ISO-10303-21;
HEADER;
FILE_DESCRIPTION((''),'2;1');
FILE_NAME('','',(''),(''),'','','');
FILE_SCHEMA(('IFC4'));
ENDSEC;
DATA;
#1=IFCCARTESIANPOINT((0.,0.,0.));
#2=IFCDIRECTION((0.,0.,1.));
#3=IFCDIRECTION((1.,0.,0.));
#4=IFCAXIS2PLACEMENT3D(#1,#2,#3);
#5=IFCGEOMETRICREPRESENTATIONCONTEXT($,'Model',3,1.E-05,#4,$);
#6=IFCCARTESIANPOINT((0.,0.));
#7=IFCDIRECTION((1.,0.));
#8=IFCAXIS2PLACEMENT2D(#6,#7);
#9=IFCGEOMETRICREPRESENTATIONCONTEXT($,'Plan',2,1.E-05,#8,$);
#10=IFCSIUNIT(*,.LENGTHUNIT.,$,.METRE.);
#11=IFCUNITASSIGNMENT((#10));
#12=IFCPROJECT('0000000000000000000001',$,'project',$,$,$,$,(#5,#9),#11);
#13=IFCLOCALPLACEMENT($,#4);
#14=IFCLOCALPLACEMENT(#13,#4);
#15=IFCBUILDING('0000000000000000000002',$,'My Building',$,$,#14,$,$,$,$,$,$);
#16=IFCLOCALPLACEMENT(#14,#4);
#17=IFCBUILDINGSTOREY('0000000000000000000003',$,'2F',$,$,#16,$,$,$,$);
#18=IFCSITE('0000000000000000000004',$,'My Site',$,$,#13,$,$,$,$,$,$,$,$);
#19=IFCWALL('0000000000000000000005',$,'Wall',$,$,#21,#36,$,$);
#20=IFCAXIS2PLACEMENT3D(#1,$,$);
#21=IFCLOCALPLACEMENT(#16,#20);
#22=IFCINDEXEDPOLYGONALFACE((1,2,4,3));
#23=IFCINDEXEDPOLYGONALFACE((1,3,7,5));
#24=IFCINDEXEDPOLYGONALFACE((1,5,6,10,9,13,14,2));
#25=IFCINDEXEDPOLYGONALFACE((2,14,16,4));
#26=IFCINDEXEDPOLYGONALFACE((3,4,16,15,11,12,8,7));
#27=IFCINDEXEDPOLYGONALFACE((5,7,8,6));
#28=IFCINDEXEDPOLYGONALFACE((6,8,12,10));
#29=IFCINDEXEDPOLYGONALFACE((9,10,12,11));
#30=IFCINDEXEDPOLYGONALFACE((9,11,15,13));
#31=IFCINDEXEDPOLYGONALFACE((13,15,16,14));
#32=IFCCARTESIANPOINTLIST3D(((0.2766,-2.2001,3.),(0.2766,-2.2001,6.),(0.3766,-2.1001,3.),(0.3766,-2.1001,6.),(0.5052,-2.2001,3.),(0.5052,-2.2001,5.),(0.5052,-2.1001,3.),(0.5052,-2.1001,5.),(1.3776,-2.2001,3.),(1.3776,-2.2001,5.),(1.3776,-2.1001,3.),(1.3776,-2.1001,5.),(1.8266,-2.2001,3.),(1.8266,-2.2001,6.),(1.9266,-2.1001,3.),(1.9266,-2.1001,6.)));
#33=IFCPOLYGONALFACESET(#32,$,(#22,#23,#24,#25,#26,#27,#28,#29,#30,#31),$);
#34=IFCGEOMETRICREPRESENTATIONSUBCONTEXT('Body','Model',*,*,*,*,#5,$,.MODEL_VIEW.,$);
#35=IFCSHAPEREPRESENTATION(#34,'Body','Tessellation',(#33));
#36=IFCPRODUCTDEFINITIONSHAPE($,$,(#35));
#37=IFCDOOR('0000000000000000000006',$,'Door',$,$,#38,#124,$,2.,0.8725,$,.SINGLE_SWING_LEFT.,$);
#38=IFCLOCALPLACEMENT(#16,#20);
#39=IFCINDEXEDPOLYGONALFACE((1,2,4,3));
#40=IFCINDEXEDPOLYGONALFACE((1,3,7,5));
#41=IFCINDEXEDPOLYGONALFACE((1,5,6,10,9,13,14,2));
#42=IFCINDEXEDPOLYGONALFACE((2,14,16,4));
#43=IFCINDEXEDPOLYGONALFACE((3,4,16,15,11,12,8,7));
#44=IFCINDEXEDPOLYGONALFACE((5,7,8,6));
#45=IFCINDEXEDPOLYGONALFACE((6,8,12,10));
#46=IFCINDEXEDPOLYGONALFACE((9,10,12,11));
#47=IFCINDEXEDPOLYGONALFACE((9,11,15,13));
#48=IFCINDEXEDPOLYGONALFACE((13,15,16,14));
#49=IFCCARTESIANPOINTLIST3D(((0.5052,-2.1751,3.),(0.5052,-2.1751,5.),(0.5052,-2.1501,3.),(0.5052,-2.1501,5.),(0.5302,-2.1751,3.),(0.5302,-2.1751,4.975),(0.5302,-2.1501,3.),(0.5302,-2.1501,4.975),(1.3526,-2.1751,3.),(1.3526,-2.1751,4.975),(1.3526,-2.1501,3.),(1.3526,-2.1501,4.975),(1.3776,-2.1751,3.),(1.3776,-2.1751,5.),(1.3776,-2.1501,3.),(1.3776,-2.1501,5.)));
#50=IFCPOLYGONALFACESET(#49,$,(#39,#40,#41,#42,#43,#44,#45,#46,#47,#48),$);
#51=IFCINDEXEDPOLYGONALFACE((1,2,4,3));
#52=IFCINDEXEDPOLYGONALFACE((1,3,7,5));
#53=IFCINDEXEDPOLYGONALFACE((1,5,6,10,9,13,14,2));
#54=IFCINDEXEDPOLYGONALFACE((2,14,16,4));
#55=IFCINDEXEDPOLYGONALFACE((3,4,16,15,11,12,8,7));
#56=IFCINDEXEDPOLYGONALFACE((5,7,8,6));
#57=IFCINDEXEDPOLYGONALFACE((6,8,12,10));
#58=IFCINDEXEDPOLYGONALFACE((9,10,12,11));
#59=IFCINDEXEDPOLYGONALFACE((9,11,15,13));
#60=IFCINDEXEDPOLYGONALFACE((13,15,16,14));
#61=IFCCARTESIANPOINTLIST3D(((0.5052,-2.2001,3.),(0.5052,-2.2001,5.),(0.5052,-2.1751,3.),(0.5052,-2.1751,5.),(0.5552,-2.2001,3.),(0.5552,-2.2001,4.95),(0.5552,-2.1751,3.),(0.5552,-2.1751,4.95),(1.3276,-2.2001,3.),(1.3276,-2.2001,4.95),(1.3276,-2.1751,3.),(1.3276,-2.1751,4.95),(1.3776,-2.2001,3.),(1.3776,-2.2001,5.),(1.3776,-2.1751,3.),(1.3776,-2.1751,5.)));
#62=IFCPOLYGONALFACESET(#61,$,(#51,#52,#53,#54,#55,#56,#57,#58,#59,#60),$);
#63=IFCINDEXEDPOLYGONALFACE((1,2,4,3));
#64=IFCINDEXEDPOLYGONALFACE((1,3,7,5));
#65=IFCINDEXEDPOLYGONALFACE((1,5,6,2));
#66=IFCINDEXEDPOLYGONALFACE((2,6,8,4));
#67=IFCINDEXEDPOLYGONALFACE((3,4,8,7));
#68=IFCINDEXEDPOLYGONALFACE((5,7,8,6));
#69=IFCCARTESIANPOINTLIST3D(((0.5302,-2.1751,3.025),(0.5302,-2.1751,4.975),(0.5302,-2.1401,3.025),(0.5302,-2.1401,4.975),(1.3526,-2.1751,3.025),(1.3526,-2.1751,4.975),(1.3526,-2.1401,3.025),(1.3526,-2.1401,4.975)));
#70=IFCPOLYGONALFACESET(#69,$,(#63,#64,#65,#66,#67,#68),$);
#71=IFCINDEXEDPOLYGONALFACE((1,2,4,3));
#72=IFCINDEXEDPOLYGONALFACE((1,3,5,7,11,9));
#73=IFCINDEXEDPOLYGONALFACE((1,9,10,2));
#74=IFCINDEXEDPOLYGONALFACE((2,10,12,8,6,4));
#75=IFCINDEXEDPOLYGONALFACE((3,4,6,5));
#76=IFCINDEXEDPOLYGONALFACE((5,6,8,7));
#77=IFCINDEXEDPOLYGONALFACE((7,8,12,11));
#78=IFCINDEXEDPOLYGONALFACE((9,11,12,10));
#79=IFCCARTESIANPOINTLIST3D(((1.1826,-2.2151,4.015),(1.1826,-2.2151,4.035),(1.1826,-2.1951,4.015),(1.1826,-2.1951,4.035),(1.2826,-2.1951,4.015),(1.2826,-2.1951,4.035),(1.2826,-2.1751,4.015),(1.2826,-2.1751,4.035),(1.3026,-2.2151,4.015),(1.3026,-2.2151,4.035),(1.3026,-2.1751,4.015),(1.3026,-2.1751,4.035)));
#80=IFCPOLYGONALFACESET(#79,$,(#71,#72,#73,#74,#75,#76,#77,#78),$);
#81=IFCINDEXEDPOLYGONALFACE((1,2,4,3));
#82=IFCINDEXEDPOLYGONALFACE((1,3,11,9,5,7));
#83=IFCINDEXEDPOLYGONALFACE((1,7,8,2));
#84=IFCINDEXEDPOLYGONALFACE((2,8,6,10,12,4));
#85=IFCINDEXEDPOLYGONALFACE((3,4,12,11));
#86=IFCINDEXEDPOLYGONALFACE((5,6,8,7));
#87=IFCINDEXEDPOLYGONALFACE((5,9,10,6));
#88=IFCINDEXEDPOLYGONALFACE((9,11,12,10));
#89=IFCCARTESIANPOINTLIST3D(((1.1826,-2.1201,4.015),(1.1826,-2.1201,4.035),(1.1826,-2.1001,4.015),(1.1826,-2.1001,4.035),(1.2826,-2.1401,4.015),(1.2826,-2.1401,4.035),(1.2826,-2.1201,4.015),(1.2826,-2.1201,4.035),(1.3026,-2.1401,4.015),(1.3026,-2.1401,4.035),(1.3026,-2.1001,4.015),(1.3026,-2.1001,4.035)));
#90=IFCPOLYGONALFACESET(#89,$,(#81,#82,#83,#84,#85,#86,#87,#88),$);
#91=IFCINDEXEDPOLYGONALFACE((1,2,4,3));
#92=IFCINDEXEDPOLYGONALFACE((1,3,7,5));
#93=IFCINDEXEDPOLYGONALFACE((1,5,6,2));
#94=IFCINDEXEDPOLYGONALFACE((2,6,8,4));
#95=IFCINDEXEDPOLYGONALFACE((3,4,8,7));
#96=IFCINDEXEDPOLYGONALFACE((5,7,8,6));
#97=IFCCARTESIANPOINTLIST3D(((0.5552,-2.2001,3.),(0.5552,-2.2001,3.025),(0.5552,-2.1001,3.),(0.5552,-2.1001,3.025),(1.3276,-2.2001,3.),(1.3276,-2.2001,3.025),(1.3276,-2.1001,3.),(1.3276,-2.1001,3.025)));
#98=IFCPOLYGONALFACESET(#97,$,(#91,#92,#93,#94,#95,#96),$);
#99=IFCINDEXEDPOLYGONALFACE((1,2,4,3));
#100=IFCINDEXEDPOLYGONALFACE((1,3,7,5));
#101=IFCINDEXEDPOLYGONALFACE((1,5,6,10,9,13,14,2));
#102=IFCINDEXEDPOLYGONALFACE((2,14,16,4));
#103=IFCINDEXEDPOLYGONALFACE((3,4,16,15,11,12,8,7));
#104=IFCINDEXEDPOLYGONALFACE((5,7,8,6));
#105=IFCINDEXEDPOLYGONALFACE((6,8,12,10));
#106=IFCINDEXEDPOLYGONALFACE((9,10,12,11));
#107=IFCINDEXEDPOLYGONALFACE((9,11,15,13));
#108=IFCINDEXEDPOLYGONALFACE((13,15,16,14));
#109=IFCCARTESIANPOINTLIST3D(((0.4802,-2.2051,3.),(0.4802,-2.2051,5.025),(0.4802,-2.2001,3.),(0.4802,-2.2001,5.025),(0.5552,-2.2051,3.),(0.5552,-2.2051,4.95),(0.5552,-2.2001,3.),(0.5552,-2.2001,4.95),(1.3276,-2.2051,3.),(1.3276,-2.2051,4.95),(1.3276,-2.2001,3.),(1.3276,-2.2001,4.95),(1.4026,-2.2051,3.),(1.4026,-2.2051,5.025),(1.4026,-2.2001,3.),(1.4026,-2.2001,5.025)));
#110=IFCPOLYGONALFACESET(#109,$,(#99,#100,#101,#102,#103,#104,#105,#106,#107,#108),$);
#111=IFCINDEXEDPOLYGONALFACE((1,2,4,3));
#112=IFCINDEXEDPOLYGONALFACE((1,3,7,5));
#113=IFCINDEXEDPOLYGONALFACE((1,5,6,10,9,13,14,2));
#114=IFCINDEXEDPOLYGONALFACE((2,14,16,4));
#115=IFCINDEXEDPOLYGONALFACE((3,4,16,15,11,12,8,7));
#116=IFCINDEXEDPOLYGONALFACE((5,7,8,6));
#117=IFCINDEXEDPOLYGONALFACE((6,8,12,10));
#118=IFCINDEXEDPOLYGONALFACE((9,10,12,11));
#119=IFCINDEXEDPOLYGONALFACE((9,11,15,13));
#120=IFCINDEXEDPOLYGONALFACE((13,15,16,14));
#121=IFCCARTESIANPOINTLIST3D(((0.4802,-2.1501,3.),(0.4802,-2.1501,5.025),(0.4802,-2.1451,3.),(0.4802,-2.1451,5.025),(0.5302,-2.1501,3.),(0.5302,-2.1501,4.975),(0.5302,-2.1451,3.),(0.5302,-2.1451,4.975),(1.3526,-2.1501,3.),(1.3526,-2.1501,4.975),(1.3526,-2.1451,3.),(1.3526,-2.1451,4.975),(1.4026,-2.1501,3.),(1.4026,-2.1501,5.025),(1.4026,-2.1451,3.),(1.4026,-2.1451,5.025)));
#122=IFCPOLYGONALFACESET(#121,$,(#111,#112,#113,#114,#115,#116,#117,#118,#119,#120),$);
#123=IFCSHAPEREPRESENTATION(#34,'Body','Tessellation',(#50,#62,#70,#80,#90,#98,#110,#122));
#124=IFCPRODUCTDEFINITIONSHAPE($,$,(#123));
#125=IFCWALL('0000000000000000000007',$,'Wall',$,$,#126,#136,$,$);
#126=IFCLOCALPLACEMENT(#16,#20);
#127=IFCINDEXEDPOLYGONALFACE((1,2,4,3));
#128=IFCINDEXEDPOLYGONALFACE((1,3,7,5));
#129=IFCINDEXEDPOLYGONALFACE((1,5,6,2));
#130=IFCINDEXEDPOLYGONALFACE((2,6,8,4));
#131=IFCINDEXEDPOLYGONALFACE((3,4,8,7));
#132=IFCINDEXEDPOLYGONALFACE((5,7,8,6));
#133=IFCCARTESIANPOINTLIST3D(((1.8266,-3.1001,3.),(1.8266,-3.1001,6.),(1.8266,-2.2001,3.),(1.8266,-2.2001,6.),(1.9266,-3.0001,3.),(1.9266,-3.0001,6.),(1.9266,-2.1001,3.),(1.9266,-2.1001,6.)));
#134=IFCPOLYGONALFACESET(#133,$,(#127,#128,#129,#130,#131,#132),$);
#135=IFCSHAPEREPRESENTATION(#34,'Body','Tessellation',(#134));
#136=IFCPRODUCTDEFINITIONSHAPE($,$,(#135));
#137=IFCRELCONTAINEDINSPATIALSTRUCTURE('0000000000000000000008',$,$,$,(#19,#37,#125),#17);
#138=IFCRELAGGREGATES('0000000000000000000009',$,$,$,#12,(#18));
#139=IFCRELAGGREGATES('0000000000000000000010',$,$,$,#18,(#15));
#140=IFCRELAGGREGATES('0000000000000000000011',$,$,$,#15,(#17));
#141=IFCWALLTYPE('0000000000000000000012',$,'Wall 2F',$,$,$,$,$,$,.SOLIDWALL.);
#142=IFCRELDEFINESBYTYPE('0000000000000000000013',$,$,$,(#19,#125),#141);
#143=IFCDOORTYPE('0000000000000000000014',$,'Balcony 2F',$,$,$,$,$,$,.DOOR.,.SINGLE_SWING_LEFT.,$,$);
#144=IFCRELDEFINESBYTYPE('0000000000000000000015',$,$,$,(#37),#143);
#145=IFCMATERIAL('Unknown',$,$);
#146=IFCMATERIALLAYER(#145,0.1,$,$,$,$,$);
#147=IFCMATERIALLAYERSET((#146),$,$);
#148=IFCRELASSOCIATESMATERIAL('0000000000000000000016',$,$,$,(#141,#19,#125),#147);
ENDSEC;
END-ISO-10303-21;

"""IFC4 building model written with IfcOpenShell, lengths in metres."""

from ifc_helpers import new_model, entity, si_unit, frame, origin_with_axes, origin_2d_with_axis, place, context, subcontext, project, spatial, line, indexed_curve, outline, extrude, shape, source, transform, mapped, material, layer, layer_set, layer_usage, type_object, type_shapes, element, fill, save


model = new_model("IFC4")

# Units and contexts
model_context = context("Model", 3, precision=1e-05, world=origin_with_axes())
plan_context = context("Plan", 2, precision=1e-05, world=origin_2d_with_axis())
body_context_1 = subcontext(model_context, "Body", "Model", "MODEL_VIEW")
body_context_2 = subcontext(plan_context, "Body", "Plan", "PLAN_VIEW")
ifc_project = project(units=[si_unit("LENGTHUNIT", "METRE")], contexts=[model_context, plan_context])

# Site, building, storey
site_placement = place(None, origin_with_axes())
site = spatial("IfcSite", under=ifc_project, at=site_placement, Name="My Site")
building_placement = place(site_placement, origin_with_axes())
building = spatial("IfcBuilding", under=site, at=building_placement, Name="My Building")
storey_placement = place(building_placement, origin_with_axes())
storey = spatial("IfcBuildingStorey", under=building, at=storey_placement, Name="2F")

# Shared definitions
ifc_material = material(Name="Unknown")

# Shared definitions
ifc_layer = layer(ifc_material, 0.1)
ifc_layer_set = layer_set([ifc_layer])
wall_type = type_object("IfcWallType", Name="Wall 2F", PredefinedType="SOLIDWALL", material=ifc_layer_set)

# Wall, opening, door
ifc_layer_usage_1 = layer_usage(ifc_layer_set, "AXIS2", "POSITIVE", 0.0)
wall_1_placement = place(storey_placement, frame((0.2766, -2.2001, 3.0), z_axis=(0.0, 0.0, 1.0), x_axis=(1.0, 0.0, 0.0)))
wall_1 = element("IfcWall", 1, at=wall_1_placement, inside=storey, type_object=wall_type, material=ifc_layer_usage_1, Name="Wall", context=body_context_1, shape_type="SweptSolid", body=[
    extrude(outline(indexed_curve([(0.0, 0.0), (0.1, 0.1), (1.65, 0.1), (1.55, 0.0)], segments=[line(1, 2, 3, 4, 1)])), origin_with_axes(), (0.0, 0.0, 1.0), 3.0),
])
shared_shape_1 = source(origin_with_axes(), body_context_1, "Body", "SweptSolid", [
    extrude(outline(indexed_curve([(0.0, 0.0), (0.8725, 0.0), (0.8725, 2.0), (0.0, 2.0)], segments=[line(1, 2, 3, 4, 1)])), frame((0.0, -0.6, 0.0), z_axis=(0.0, -1.0, 0.0), x_axis=(1.0, 0.0, 0.0)), (0.0, 0.0, -1.0), 1.2),
])
opening_1_placement = place(wall_1_placement, frame((0.2286, 0.0, 0.0), z_axis=(0.0, 0.0, 1.0), x_axis=(1.0, 0.0, 0.0)))
opening_1 = element("IfcOpeningElement", 2, at=opening_1_placement, cuts=wall_1, PredefinedType="OPENING", context=body_context_1, shape_type="MappedRepresentation", body=[
    mapped(shared_shape_1, transform((0.0, 0.0, 0.0), x_axis=(1.0, 0.0, 0.0), y_axis=(0.0, 1.0, 0.0), z_axis=(0.0, 0.0, 1.0), scale=1.0)),
])
door_type_1 = type_object("IfcDoorType", Name="Balcony 2F", OperationType="SINGLE_SWING_LEFT", PredefinedType="DOOR")
shared_shape_2 = source(origin_with_axes(), body_context_1, "Body", "SweptSolid", [
    extrude(outline(indexed_curve([(0.0, 0.0), (0.0, 2.0), (0.8725, 2.0), (0.8725, 0.0), (0.8475, 0.0), (0.8475, 1.975), (0.025, 1.975), (0.025, 0.0)], segments=[line(1, 2, 3, 4, 5, 6, 7, 8, 1)])), frame((0.0, 0.025, 0.0), z_axis=(0.0, -1.0, 0.0), x_axis=(1.0, 0.0, 0.0)), (0.0, 0.0, -1.0), 0.025),
    extrude(outline(indexed_curve([(0.0, 0.0), (0.0, 2.0), (0.8725, 2.0), (0.8725, 0.0), (0.8225, 0.0), (0.8225, 1.95), (0.05, 1.95), (0.05, 0.0)], segments=[line(1, 2, 3, 4, 5, 6, 7, 8, 1)])), frame((0.0, 0.0, 0.0), z_axis=(0.0, -1.0, 0.0), x_axis=(1.0, 0.0, 0.0)), (0.0, 0.0, -1.0), 0.025),
    extrude(outline(indexed_curve([(0.0, 0.0), (0.8225, 0.0), (0.8225, 0.035), (0.0, 0.035)], segments=[line(1, 2, 3, 4, 1)])), frame((0.025, 0.025, 0.025), z_axis=(0.0, 0.0, 1.0), x_axis=(1.0, 0.0, 0.0)), (0.0, 0.0, 1.0), 1.95),
    extrude(outline(indexed_curve([(0.0, 0.0), (0.0, -0.04), (-0.12, -0.04), (-0.12, -0.02), (-0.02, -0.02), (-0.02, 0.0)], segments=[line(1, 2, 3, 4, 5, 6, 1)])), frame((0.7975, 0.025, 1.015), z_axis=(0.0, 0.0, 1.0), x_axis=(1.0, 0.0, 0.0)), (0.0, 0.0, 1.0), 0.02),
    extrude(outline(indexed_curve([(0.0, 0.0), (0.0, 0.04), (-0.12, 0.04), (-0.12, 0.02), (-0.02, 0.02), (-0.02, 0.0)], segments=[line(1, 2, 3, 4, 5, 6, 1)])), frame((0.7975, 0.06, 1.015), z_axis=(0.0, 0.0, 1.0), x_axis=(1.0, 0.0, 0.0)), (0.0, 0.0, 1.0), 0.02),
    extrude(outline(indexed_curve([(0.0, 0.0), (0.7725, 0.0), (0.7725, 0.1), (0.0, 0.1)], segments=[line(1, 2, 3, 4, 1)])), frame((0.05, 0.0, 0.0), z_axis=(0.0, 0.0, 1.0), x_axis=(1.0, 0.0, 0.0)), (0.0, 0.0, 1.0), 0.025),
    extrude(outline(indexed_curve([(0.0, 0.0), (0.0, 2.025), (0.9225, 2.025), (0.9225, 0.0), (0.8475, 0.0), (0.8475, 1.95), (0.075, 1.95), (0.075, 0.0)], segments=[line(1, 2, 3, 4, 5, 6, 7, 8, 1)])), frame((-0.025, -0.005, 0.0), z_axis=(0.0, -1.0, 0.0), x_axis=(1.0, 0.0, 0.0)), (0.0, 0.0, -1.0), 0.005),
    extrude(outline(indexed_curve([(0.0, 0.0), (0.0, 2.025), (0.9225, 2.025), (0.9225, 0.0), (0.8725, 0.0), (0.8725, 1.975), (0.05, 1.975), (0.05, 0.0)], segments=[line(1, 2, 3, 4, 5, 6, 7, 8, 1)])), frame((-0.025, 0.05, 0.0), z_axis=(0.0, -1.0, 0.0), x_axis=(1.0, 0.0, 0.0)), (0.0, 0.0, -1.0), 0.005),
])
shared_shape_3 = source(origin_with_axes(), body_context_2, "Body", "Curve2D", [
    entity("IfcIndexedPolyCurve", entity("IfcCartesianPointList2D", [[0.0, 0.0], [0.0, 0.05], [0.025, 0.05], [0.025, 0.025], [0.05, 0.025], [0.05, 0.0]]), [entity("IfcLineIndex", [1, 2, 3, 4, 5, 6, 1])]),
    entity("IfcIndexedPolyCurve", entity("IfcCartesianPointList2D", [[0.8725, 0.0], [0.8725, 0.05], [0.8475, 0.05], [0.8475, 0.025], [0.8225, 0.025], [0.8225, 0.0]]), [entity("IfcLineIndex", [1, 2, 3, 4, 5, 6, 1])]),
    entity("IfcTrimmedCurve", entity("IfcEllipse", entity("IfcAxis2Placement2D", entity("IfcCartesianPoint", [0.06, 0.05]), entity("IfcDirection", [1.0, 0.0])), 0.7875, 0.8225), [entity("IfcCartesianPoint", [0.8475, 0.05])], [entity("IfcCartesianPoint", [0.06, 0.8725])], True, "CARTESIAN"),
    entity("IfcIndexedPolyCurve", entity("IfcCartesianPointList2D", [[0.025, 0.05], [0.06, 0.05], [0.06, 0.8725], [0.025, 0.8725]]), [entity("IfcLineIndex", [1, 2, 3, 4, 1])]),
])
type_shapes(door_type_1, [shared_shape_2, shared_shape_3])
door_1_placement = place(opening_1_placement, frame((0.0, 0.0, 0.0), z_axis=(0.0, 0.0, 1.0), x_axis=(1.0, 0.0, 0.0)))
door_1 = element("IfcDoor", 3, at=door_1_placement, inside=storey, type_object=door_type_1, Name="Door", OperationType="SINGLE_SWING_LEFT", OverallHeight=2.0, OverallWidth=0.8725, shapes=[
    shape(body_context_1, "Body", "MappedRepresentation", [mapped(shared_shape_2, transform((0.0, 0.0, 0.0), x_axis=(1.0, 0.0, 0.0), y_axis=(0.0, 1.0, 0.0), z_axis=(0.0, 0.0, 1.0), scale=1.0))]),
    shape(body_context_2, "Body", "MappedRepresentation", [mapped(shared_shape_3, transform((0.0, 0.0, 0.0), x_axis=(1.0, 0.0, 0.0), y_axis=(0.0, 1.0, 0.0), z_axis=(0.0, 0.0, 1.0), scale=1.0))]),
])
fill(opening_1, door_1)

# Wall
ifc_layer_usage_2 = layer_usage(ifc_layer_set, "AXIS2", "POSITIVE", 0.0)
wall_2_placement = place(storey_placement, frame((1.8266, -2.2001, 3.0), z_axis=(0.0, 0.0, 1.0), x_axis=(0.0, -1.0, 0.0)))
element("IfcWall", 4, at=wall_2_placement, inside=storey, type_object=wall_type, material=ifc_layer_usage_2, Name="Wall", context=body_context_1, shape_type="SweptSolid", body=[
    extrude(outline(indexed_curve([(0.0, 0.0), (-0.1, 0.1), (0.8, 0.1), (0.9, 0.0)], segments=[line(1, 2, 3, 4, 1)])), origin_with_axes(), (0.0, 0.0, 1.0), 3.0),
])

save(model, "model.ifc")
